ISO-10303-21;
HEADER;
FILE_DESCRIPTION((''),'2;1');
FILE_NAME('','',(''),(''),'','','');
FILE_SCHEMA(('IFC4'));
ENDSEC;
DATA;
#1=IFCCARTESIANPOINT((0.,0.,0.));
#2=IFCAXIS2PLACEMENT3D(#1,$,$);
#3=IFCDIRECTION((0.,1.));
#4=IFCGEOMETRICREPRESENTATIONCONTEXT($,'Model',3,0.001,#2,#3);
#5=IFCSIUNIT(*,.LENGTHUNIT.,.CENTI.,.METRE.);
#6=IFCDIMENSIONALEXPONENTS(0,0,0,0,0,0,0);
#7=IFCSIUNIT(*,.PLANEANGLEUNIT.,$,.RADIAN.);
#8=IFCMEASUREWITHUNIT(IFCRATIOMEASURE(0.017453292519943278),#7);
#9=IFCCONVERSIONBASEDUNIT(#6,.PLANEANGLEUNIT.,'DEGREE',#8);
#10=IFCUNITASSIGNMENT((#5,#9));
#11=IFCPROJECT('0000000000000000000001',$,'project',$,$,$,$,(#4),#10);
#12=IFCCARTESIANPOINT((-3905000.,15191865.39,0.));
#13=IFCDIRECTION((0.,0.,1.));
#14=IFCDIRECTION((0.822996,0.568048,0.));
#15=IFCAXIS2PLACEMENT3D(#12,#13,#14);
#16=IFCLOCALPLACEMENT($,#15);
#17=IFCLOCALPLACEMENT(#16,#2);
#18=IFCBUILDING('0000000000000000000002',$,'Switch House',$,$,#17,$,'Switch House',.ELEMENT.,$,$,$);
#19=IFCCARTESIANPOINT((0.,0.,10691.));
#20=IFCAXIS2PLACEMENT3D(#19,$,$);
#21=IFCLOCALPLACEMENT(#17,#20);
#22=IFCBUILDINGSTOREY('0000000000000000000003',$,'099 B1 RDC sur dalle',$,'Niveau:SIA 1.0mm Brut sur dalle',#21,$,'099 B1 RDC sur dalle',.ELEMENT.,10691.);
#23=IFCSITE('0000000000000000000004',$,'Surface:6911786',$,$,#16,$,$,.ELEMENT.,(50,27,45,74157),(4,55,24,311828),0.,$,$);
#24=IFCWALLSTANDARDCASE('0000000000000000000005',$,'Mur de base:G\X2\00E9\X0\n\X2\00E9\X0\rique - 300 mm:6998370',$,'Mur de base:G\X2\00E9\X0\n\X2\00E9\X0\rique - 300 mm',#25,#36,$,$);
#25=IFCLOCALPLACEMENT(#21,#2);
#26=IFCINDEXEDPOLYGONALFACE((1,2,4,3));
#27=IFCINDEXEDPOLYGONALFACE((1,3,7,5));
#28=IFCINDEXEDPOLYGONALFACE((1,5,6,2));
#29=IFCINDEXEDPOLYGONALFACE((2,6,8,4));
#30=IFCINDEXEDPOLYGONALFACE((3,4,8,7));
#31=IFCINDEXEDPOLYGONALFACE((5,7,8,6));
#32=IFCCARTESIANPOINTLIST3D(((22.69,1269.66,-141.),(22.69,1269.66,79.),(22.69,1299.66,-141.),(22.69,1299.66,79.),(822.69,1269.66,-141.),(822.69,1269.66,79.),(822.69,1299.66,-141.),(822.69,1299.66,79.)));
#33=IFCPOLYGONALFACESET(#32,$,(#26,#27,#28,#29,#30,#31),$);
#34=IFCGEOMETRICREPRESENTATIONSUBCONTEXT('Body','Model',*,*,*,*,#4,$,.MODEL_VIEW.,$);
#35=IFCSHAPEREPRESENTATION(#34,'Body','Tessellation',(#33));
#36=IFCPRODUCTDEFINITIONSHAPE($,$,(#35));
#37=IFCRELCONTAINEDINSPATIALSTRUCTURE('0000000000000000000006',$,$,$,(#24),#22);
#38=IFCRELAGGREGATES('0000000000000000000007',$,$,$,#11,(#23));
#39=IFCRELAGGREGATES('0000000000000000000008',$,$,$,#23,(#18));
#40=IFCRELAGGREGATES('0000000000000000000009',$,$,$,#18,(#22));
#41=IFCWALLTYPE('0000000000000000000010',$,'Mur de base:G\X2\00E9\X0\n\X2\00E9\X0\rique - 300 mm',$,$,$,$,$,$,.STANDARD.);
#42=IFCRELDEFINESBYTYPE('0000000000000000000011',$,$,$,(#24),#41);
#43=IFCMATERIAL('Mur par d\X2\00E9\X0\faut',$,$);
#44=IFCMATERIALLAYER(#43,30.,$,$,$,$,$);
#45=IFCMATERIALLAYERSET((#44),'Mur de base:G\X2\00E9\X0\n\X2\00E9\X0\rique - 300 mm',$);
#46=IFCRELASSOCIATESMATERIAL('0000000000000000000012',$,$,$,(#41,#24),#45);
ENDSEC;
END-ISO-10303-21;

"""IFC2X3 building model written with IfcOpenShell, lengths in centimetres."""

from ifc_helpers import new_model, entity, si_unit, converted_unit, direction, frame, frame_2d, origin, place, context, subcontext, project, spatial, rectangle, extrude, material, layer, layer_set, layer_usage, type_object, element, save


model = new_model("IFC2X3")

# Units and contexts
model_context = context("Model", 3, precision=0.001, world=origin(), true_north=direction((0.0, 1.0)))
body_context = subcontext(model_context, "Body", "Model", "MODEL_VIEW")
ifc_project = project(units=[si_unit("LENGTHUNIT", "METRE", prefix="CENTI"), converted_unit("PLANEANGLEUNIT", "DEGREE", entity("IfcRatioMeasure", 0.017453292519943278), si_unit("PLANEANGLEUNIT", "RADIAN"), dimensions=[0, 0, 0, 0, 0, 0, 0])], contexts=[model_context])

# Site, building, storey
site_placement = place(None, frame((-3905000.0, 15191865.39, 0.0), z_axis=(0.0, 0.0, 1.0), x_axis=(0.822996, 0.568048, 0.0)))
site = spatial("IfcSite", under=ifc_project, at=site_placement, Name="Surface:6911786", CompositionType="ELEMENT", RefLatitude=(50, 27, 45, 74157), RefLongitude=(4, 55, 24, 311828), RefElevation=0.0)
building_placement = place(site_placement, origin())
building = spatial("IfcBuilding", under=site, at=building_placement, Name="Switch House", LongName="Switch House", CompositionType="ELEMENT")
storey_placement = place(building_placement, frame((0.0, 0.0, 10691.0)))
storey = spatial("IfcBuildingStorey", under=building, at=storey_placement, Name="099 B1 RDC sur dalle", ObjectType="Niveau:SIA 1.0mm Brut sur dalle", LongName="099 B1 RDC sur dalle", CompositionType="ELEMENT", Elevation=10691.0)

# Wall
ifc_material_1 = material(Name="Mur par défaut")
ifc_layer_1 = layer(ifc_material_1, 30.0)
ifc_layer_set_1 = layer_set([ifc_layer_1], Name="Mur de base:Générique - 300 mm")
wall_type_1 = type_object("IfcWallType", Name="Mur de base:Générique - 300 mm", PredefinedType="STANDARD", material=ifc_layer_set_1)
ifc_layer_usage_1 = layer_usage(ifc_layer_set_1, "AXIS2", "NEGATIVE", 15.0)
wall_1_placement = place(storey_placement, frame((822.69, 1284.66, -141.0), z_axis=(0.0, 0.0, 1.0), x_axis=(-1.0, 0.0, 0.0)))
element("IfcWallStandardCase", 1, at=wall_1_placement, inside=storey, type_object=wall_type_1, material=ifc_layer_usage_1, Name="Mur de base:Générique - 300 mm:6998370", ObjectType="Mur de base:Générique - 300 mm", context=body_context, shape_type="SweptSolid", body=[
    extrude(rectangle(XDim=800.0, YDim=30.0, at=frame_2d((400.0, 0.0), x_axis=(-1.0, 0.0))), origin(), (0.0, 0.0, 1.0), 220.0),
])

save(model, "model.ifc")
